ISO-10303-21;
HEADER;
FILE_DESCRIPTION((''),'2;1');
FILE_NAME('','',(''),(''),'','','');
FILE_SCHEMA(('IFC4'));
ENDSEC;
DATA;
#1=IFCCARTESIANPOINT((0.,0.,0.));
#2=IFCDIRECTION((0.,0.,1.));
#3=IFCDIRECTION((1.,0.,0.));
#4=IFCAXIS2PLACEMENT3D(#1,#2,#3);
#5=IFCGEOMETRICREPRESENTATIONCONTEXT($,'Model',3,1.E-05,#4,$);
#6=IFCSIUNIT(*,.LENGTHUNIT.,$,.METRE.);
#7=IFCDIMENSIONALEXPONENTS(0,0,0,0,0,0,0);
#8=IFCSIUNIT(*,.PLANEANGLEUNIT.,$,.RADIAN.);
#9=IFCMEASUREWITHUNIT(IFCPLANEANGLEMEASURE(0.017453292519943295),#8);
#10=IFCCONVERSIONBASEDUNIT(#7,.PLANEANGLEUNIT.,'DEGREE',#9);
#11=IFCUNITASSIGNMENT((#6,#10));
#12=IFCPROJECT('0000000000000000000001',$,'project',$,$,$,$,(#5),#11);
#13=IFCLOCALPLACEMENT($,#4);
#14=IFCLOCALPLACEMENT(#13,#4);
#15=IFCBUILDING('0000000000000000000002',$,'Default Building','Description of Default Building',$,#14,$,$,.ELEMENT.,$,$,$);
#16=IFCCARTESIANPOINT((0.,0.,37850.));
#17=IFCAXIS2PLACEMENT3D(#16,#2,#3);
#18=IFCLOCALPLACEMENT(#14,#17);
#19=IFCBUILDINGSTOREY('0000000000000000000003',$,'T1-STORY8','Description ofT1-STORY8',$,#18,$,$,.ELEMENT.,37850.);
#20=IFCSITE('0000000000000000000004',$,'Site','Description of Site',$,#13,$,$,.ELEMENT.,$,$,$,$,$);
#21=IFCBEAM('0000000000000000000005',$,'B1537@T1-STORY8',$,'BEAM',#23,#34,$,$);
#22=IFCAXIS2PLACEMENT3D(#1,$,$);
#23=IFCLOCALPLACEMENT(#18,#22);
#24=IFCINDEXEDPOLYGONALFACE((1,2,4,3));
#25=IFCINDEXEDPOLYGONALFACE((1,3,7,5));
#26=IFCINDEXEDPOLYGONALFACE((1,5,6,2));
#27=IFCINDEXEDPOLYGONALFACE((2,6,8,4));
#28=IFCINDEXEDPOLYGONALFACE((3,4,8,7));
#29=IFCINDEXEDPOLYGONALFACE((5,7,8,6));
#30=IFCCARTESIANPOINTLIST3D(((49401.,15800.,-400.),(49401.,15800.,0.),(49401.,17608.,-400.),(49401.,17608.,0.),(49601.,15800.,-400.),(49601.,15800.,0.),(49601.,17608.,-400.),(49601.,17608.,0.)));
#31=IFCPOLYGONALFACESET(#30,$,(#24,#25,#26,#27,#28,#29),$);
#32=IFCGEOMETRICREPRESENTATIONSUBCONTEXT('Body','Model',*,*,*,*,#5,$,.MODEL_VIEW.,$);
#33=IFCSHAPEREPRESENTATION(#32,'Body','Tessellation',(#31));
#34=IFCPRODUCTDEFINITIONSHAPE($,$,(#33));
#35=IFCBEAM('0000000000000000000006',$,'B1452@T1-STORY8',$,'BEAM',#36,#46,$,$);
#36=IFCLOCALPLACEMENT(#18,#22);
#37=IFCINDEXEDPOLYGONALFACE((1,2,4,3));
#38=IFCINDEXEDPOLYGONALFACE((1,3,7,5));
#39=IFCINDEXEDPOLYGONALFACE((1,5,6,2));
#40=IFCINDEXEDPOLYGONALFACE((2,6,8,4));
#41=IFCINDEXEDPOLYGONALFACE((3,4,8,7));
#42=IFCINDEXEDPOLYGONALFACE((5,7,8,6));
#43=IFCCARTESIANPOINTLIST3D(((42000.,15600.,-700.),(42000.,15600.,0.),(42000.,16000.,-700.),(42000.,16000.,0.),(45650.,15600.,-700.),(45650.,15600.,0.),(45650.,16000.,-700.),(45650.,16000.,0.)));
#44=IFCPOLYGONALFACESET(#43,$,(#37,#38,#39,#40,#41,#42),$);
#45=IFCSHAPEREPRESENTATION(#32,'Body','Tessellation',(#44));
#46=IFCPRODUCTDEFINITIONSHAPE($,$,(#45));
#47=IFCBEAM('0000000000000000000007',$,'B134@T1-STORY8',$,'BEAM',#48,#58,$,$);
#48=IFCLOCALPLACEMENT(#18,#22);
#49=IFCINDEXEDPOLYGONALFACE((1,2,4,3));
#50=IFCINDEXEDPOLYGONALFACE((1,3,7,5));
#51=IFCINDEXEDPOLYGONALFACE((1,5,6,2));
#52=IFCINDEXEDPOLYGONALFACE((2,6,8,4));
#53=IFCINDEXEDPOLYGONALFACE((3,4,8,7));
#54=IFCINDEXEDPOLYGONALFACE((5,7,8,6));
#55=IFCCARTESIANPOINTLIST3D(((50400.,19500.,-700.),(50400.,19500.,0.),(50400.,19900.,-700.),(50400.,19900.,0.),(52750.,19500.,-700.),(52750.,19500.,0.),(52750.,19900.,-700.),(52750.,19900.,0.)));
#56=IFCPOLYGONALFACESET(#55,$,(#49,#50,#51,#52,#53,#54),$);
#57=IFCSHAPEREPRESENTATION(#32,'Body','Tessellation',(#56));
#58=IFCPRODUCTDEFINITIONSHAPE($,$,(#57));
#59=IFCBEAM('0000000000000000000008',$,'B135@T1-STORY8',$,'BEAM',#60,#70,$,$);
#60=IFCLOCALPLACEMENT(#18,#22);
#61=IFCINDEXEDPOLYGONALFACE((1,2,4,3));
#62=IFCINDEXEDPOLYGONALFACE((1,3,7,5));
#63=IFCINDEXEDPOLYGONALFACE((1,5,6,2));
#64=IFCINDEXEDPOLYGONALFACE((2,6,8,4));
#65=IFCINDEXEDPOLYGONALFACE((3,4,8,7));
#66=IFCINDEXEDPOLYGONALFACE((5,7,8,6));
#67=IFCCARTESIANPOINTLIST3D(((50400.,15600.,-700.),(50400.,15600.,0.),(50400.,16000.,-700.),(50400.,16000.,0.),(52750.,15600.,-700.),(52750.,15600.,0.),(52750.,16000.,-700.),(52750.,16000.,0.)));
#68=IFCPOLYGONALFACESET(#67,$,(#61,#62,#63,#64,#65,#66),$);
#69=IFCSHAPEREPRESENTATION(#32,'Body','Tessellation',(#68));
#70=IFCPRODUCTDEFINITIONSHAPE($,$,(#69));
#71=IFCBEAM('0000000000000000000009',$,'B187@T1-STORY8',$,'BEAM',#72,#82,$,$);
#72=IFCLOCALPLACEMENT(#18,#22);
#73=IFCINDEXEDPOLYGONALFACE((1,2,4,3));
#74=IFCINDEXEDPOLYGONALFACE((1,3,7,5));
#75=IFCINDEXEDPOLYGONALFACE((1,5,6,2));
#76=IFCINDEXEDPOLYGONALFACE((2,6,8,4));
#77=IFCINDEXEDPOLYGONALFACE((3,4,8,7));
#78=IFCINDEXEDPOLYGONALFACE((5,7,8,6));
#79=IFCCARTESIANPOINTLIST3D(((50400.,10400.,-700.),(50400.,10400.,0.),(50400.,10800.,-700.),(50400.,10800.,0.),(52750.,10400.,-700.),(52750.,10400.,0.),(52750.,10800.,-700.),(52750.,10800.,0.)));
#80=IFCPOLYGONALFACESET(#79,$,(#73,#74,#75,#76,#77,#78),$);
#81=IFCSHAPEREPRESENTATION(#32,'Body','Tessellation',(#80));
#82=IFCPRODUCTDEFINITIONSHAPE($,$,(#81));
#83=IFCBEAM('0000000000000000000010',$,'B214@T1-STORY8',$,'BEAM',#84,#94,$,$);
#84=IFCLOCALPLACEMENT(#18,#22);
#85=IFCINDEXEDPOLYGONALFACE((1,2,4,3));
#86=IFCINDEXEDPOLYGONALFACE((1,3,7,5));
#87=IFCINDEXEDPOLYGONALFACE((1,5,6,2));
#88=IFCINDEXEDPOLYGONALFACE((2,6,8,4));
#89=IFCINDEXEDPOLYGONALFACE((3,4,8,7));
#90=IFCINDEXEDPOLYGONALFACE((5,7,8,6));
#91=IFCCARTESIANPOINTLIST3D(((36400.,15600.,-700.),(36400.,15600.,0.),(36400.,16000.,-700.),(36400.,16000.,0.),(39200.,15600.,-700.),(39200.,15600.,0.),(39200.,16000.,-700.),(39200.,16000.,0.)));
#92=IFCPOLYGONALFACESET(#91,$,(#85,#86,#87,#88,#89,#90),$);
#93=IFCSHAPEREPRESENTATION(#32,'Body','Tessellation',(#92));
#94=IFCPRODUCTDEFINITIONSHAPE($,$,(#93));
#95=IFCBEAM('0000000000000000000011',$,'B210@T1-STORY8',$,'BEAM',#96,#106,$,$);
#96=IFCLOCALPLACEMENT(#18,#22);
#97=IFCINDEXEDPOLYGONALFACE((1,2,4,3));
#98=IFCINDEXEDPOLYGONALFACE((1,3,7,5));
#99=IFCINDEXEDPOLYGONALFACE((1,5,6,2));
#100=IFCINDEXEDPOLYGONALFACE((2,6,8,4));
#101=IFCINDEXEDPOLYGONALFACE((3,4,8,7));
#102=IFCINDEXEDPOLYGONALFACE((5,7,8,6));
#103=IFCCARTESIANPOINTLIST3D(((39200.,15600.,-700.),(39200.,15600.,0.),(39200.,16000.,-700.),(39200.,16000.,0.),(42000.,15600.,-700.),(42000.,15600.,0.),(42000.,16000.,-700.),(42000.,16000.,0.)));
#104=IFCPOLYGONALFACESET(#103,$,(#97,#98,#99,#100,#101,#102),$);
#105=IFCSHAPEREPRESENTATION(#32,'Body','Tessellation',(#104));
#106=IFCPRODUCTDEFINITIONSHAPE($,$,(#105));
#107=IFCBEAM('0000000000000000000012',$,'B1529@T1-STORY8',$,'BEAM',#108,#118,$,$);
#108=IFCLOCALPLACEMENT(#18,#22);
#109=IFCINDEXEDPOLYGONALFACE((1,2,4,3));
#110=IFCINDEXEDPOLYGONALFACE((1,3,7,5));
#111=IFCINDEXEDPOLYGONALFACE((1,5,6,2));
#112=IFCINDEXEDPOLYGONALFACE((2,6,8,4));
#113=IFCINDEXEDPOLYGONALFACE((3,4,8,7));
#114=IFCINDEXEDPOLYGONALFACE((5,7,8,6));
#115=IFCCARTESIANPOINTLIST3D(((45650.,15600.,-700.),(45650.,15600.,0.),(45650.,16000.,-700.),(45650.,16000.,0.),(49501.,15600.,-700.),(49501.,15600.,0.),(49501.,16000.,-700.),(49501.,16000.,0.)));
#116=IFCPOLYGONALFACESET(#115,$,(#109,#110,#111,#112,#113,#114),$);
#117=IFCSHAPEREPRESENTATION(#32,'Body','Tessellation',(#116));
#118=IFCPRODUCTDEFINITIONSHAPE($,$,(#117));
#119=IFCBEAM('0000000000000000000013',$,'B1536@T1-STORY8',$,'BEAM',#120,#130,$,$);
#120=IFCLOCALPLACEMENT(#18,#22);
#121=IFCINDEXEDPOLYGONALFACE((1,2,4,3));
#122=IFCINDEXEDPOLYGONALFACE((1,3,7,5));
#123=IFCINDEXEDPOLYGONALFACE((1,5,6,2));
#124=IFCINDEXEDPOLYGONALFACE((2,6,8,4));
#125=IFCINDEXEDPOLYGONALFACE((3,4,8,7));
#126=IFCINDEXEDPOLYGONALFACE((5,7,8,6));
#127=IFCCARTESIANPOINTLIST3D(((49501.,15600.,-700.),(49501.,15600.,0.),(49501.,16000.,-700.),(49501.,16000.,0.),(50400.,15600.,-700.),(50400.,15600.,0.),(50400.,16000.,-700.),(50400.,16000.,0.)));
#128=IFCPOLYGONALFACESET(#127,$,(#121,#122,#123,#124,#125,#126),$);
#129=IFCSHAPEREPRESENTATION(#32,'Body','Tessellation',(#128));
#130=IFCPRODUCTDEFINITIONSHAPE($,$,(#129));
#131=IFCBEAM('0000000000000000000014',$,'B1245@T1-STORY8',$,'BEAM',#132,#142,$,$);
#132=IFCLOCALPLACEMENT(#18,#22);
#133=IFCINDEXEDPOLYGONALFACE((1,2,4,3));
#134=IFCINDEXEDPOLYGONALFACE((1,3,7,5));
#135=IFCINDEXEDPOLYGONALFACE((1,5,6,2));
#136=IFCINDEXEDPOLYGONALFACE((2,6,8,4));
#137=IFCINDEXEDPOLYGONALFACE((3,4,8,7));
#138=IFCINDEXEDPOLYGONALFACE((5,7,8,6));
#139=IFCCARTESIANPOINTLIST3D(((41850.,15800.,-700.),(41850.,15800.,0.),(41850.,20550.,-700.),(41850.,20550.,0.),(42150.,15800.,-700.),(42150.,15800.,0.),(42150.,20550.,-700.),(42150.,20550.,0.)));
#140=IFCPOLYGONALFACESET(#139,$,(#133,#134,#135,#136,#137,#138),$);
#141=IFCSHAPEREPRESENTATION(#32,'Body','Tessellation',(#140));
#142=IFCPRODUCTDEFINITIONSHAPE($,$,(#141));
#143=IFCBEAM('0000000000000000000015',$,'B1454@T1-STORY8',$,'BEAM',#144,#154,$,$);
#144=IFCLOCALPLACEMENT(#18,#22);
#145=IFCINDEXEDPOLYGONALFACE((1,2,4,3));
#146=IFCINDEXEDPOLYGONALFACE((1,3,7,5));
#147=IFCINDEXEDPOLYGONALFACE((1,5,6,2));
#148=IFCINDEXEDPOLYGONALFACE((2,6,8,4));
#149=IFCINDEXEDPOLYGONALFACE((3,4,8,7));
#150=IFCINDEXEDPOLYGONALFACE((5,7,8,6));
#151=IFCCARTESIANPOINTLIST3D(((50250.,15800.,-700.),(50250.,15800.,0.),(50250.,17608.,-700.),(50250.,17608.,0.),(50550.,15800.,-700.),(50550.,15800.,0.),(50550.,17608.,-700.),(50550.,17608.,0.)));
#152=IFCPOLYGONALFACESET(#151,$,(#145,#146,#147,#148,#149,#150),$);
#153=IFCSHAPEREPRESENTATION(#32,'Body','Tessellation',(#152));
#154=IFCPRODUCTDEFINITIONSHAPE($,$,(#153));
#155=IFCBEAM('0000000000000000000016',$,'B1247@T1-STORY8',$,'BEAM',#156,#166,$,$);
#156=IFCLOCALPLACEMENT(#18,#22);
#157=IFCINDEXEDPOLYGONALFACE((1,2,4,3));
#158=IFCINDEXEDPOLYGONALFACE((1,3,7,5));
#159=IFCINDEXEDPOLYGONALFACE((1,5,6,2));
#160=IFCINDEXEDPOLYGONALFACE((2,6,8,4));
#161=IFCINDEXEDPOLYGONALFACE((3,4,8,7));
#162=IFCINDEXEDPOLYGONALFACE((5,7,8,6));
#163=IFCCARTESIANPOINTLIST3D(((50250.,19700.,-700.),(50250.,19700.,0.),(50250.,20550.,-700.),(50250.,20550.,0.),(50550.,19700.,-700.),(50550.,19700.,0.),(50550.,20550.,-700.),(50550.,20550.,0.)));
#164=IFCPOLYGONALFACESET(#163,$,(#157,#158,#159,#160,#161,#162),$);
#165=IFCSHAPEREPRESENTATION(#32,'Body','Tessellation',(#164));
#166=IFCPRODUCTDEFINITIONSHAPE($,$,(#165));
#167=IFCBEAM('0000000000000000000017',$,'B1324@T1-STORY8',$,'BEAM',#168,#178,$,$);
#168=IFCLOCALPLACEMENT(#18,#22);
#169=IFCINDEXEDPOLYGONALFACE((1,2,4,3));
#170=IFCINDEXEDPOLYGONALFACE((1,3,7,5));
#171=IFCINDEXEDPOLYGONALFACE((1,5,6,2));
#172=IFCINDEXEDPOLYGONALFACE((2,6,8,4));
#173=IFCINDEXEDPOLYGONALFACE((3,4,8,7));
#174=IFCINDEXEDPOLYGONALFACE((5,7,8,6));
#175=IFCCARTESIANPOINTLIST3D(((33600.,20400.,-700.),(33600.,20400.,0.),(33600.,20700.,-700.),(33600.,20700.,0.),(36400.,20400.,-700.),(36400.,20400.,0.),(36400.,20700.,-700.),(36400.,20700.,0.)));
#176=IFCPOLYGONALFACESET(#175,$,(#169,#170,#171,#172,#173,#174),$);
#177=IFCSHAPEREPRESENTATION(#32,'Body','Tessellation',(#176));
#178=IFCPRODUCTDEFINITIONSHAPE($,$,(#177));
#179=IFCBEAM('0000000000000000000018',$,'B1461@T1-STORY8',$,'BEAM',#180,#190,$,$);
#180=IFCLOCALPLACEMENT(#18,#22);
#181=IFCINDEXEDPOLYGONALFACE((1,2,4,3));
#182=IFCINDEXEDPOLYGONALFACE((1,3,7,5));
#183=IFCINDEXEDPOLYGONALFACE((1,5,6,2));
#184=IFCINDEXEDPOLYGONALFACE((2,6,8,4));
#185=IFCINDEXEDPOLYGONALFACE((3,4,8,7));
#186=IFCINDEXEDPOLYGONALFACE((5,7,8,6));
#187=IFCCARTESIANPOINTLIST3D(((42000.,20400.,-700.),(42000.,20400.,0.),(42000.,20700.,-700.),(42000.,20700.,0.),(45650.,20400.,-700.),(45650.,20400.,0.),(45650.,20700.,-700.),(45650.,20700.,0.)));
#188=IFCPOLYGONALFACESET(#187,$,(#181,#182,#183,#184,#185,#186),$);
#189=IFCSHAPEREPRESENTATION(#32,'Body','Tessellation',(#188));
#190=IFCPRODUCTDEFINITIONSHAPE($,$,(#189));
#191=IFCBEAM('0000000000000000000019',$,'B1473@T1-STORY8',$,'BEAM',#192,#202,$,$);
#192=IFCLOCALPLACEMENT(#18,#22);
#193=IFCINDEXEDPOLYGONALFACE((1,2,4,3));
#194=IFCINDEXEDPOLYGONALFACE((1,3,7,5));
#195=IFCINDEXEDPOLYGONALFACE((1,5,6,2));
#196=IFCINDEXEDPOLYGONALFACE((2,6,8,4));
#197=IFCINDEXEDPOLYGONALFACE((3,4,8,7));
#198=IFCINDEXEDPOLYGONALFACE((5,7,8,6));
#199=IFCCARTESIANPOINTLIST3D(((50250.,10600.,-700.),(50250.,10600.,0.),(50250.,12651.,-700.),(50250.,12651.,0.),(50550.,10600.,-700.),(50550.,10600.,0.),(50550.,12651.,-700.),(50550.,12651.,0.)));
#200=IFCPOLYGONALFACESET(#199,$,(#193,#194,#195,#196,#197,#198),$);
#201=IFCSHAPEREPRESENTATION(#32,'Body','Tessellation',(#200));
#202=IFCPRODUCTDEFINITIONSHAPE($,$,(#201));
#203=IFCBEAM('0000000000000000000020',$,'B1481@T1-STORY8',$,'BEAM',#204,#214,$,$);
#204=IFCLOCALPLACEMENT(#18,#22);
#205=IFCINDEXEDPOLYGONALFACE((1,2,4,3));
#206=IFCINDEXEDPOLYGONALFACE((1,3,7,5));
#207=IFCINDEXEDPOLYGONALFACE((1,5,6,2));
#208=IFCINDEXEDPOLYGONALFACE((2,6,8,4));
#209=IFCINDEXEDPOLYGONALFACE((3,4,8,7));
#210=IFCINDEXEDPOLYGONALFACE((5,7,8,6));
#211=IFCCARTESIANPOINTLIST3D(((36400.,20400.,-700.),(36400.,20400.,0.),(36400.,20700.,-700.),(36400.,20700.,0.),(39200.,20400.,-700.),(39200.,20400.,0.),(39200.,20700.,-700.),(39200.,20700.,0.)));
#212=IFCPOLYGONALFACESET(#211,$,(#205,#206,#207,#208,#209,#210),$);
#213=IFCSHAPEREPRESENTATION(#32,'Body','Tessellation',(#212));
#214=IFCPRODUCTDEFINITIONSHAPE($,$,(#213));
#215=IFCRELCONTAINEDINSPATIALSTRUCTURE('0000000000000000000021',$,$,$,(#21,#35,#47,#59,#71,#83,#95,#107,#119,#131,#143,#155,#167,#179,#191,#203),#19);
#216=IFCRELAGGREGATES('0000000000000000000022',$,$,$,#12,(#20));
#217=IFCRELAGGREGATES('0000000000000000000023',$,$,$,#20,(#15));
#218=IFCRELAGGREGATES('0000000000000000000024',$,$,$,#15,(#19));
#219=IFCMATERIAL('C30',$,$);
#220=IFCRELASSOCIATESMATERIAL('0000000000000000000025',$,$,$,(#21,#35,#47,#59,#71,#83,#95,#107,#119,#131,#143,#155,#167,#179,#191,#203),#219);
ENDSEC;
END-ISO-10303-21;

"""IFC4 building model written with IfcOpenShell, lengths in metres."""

from ifc_helpers import new_model, entity, si_unit, converted_unit, frame, origin_with_axes, place, context, subcontext, project, spatial, rectangle, extrude, material, element, save


model = new_model("IFC4")

# Units and contexts
model_context = context("Model", 3, precision=1e-05, world=origin_with_axes())
body_context = subcontext(model_context, "Body", "Model", "MODEL_VIEW")
ifc_project = project(units=[si_unit("LENGTHUNIT", "METRE"), converted_unit("PLANEANGLEUNIT", "DEGREE", entity("IfcPlaneAngleMeasure", 0.017453292519943295), si_unit("PLANEANGLEUNIT", "RADIAN"), dimensions=[0, 0, 0, 0, 0, 0, 0])], contexts=[model_context])

# Site, building, storey
site_placement = place(None, origin_with_axes())
site = spatial("IfcSite", under=ifc_project, at=site_placement, Name="Site", Description="Description of Site", CompositionType="ELEMENT")
building_placement = place(site_placement, origin_with_axes())
building = spatial("IfcBuilding", under=site, at=building_placement, Name="Default Building", Description="Description of Default Building", CompositionType="ELEMENT")
storey_placement = place(building_placement, frame((0.0, 0.0, 37850.0), z_axis=(0.0, 0.0, 1.0), x_axis=(1.0, 0.0, 0.0)))
storey = spatial("IfcBuildingStorey", under=building, at=storey_placement, Name="T1-STORY8", Description="Description ofT1-STORY8", CompositionType="ELEMENT", Elevation=37850.0)

# Beams
ifc_material_1 = material(Name="C30")
beam_1_placement = place(storey_placement, frame((49501.0, 15800.0, -200.0), z_axis=(0.0, 1.0, 0.0), x_axis=(-1.0, 0.0, 0.0)))
element("IfcBeam", 1, at=beam_1_placement, inside=storey, material=ifc_material_1, Name="B1537@T1-STORY8", ObjectType="BEAM", context=body_context, shape_type="SweptSolid", body=[
    extrude(rectangle(XDim=200.0, YDim=400.0), origin_with_axes(), (0.0, 0.0, 1.0), 1808.0),
])
beam_2_placement = place(storey_placement, frame((42000.0, 15800.0, -350.0), z_axis=(1.0, 0.0, 0.0), x_axis=(0.0, 1.0, 0.0)))
element("IfcBeam", 2, at=beam_2_placement, inside=storey, material=ifc_material_1, Name="B1452@T1-STORY8", ObjectType="BEAM", context=body_context, shape_type="SweptSolid", body=[
    extrude(rectangle(XDim=400.0, YDim=700.0), origin_with_axes(), (0.0, 0.0, 1.0), 3650.0),
])
for number, where, z_axis, x_axis, name in (
    (3, (50400.0, 19700.0, -350.0), (1.0, 0.0, 0.0), (0.0, 1.0, 0.0), "B134@T1-STORY8"),
    (4, (50400.0, 15800.0, -350.0), (1.0, 0.0, 0.0), (0.0, 1.0, 0.0), "B135@T1-STORY8"),
    (5, (50400.0, 10600.0, -350.0), (1.0, 0.0, 0.0), (0.0, 1.0, 0.0), "B187@T1-STORY8"),
):
    element("IfcBeam", number, at=place(storey_placement, frame(where, z_axis=z_axis, x_axis=x_axis)), inside=storey, material=ifc_material_1, Name=name, ObjectType="BEAM", context=body_context, shape_type="SweptSolid", body=[
        extrude(rectangle(XDim=400.0, YDim=700.0), origin_with_axes(), (0.0, 0.0, 1.0), 2350.0),
    ])
for number, where, z_axis, x_axis, name in (
    (6, (36400.0, 15800.0, -350.0), (1.0, 0.0, 0.0), (0.0, 1.0, 0.0), "B214@T1-STORY8"),
    (7, (39200.0, 15800.0, -350.0), (1.0, 0.0, 0.0), (0.0, 1.0, 0.0), "B210@T1-STORY8"),
):
    element("IfcBeam", number, at=place(storey_placement, frame(where, z_axis=z_axis, x_axis=x_axis)), inside=storey, material=ifc_material_1, Name=name, ObjectType="BEAM", context=body_context, shape_type="SweptSolid", body=[
        extrude(rectangle(XDim=400.0, YDim=700.0), origin_with_axes(), (0.0, 0.0, 1.0), 2800.0),
    ])
beam_3_placement = place(storey_placement, frame((45650.0, 15800.0, -350.0), z_axis=(1.0, 0.0, 0.0), x_axis=(0.0, 1.0, 0.0)))
element("IfcBeam", 8, at=beam_3_placement, inside=storey, material=ifc_material_1, Name="B1529@T1-STORY8", ObjectType="BEAM", context=body_context, shape_type="SweptSolid", body=[
    extrude(rectangle(XDim=400.0, YDim=700.0), origin_with_axes(), (0.0, 0.0, 1.0), 3851.0),
])
beam_4_placement = place(storey_placement, frame((49501.0, 15800.0, -350.0), z_axis=(1.0, 0.0, 0.0), x_axis=(0.0, 1.0, 0.0)))
element("IfcBeam", 9, at=beam_4_placement, inside=storey, material=ifc_material_1, Name="B1536@T1-STORY8", ObjectType="BEAM", context=body_context, shape_type="SweptSolid", body=[
    extrude(rectangle(XDim=400.0, YDim=700.0), origin_with_axes(), (0.0, 0.0, 1.0), 899.0),
])
beam_5_placement = place(storey_placement, frame((42000.0, 15800.0, -350.0), z_axis=(0.0, 1.0, 0.0), x_axis=(-1.0, 0.0, 0.0)))
element("IfcBeam", 10, at=beam_5_placement, inside=storey, material=ifc_material_1, Name="B1245@T1-STORY8", ObjectType="BEAM", context=body_context, shape_type="SweptSolid", body=[
    extrude(rectangle(XDim=300.0, YDim=700.0), origin_with_axes(), (0.0, 0.0, 1.0), 4750.0),
])
beam_6_placement = place(storey_placement, frame((50400.0, 15800.0, -350.0), z_axis=(0.0, 1.0, 0.0), x_axis=(-1.0, 0.0, 0.0)))
element("IfcBeam", 11, at=beam_6_placement, inside=storey, material=ifc_material_1, Name="B1454@T1-STORY8", ObjectType="BEAM", context=body_context, shape_type="SweptSolid", body=[
    extrude(rectangle(XDim=300.0, YDim=700.0), origin_with_axes(), (0.0, 0.0, 1.0), 1808.0),
])
beam_7_placement = place(storey_placement, frame((50400.0, 19700.0, -350.0), z_axis=(0.0, 1.0, 0.0), x_axis=(-1.0, 0.0, 0.0)))
element("IfcBeam", 12, at=beam_7_placement, inside=storey, material=ifc_material_1, Name="B1247@T1-STORY8", ObjectType="BEAM", context=body_context, shape_type="SweptSolid", body=[
    extrude(rectangle(XDim=300.0, YDim=700.0), origin_with_axes(), (0.0, 0.0, 1.0), 850.0),
])
beam_8_placement = place(storey_placement, frame((33600.0, 20550.0, -350.0), z_axis=(1.0, 0.0, 0.0), x_axis=(0.0, 1.0, 0.0)))
element("IfcBeam", 13, at=beam_8_placement, inside=storey, material=ifc_material_1, Name="B1324@T1-STORY8", ObjectType="BEAM", context=body_context, shape_type="SweptSolid", body=[
    extrude(rectangle(XDim=300.0, YDim=700.0), origin_with_axes(), (0.0, 0.0, 1.0), 2800.0),
])
beam_9_placement = place(storey_placement, frame((42000.0, 20550.0, -350.0), z_axis=(1.0, 0.0, 0.0), x_axis=(0.0, 1.0, 0.0)))
element("IfcBeam", 14, at=beam_9_placement, inside=storey, material=ifc_material_1, Name="B1461@T1-STORY8", ObjectType="BEAM", context=body_context, shape_type="SweptSolid", body=[
    extrude(rectangle(XDim=300.0, YDim=700.0), origin_with_axes(), (0.0, 0.0, 1.0), 3650.0),
])
beam_10_placement = place(storey_placement, frame((50400.0, 10600.0, -350.0), z_axis=(0.0, 1.0, 0.0), x_axis=(-1.0, 0.0, 0.0)))
element("IfcBeam", 15, at=beam_10_placement, inside=storey, material=ifc_material_1, Name="B1473@T1-STORY8", ObjectType="BEAM", context=body_context, shape_type="SweptSolid", body=[
    extrude(rectangle(XDim=300.0, YDim=700.0), origin_with_axes(), (0.0, 0.0, 1.0), 2051.0),
])
for number, where, z_axis, x_axis, name in (
    (16, (36400.0, 20550.0, -350.0), (1.0, 0.0, 0.0), (0.0, 1.0, 0.0), "B1481@T1-STORY8"),
):
    element("IfcBeam", number, at=place(storey_placement, frame(where, z_axis=z_axis, x_axis=x_axis)), inside=storey, material=ifc_material_1, Name=name, ObjectType="BEAM", context=body_context, shape_type="SweptSolid", body=[
        extrude(rectangle(XDim=300.0, YDim=700.0), origin_with_axes(), (0.0, 0.0, 1.0), 2800.0),
    ])

save(model, "model.ifc")
